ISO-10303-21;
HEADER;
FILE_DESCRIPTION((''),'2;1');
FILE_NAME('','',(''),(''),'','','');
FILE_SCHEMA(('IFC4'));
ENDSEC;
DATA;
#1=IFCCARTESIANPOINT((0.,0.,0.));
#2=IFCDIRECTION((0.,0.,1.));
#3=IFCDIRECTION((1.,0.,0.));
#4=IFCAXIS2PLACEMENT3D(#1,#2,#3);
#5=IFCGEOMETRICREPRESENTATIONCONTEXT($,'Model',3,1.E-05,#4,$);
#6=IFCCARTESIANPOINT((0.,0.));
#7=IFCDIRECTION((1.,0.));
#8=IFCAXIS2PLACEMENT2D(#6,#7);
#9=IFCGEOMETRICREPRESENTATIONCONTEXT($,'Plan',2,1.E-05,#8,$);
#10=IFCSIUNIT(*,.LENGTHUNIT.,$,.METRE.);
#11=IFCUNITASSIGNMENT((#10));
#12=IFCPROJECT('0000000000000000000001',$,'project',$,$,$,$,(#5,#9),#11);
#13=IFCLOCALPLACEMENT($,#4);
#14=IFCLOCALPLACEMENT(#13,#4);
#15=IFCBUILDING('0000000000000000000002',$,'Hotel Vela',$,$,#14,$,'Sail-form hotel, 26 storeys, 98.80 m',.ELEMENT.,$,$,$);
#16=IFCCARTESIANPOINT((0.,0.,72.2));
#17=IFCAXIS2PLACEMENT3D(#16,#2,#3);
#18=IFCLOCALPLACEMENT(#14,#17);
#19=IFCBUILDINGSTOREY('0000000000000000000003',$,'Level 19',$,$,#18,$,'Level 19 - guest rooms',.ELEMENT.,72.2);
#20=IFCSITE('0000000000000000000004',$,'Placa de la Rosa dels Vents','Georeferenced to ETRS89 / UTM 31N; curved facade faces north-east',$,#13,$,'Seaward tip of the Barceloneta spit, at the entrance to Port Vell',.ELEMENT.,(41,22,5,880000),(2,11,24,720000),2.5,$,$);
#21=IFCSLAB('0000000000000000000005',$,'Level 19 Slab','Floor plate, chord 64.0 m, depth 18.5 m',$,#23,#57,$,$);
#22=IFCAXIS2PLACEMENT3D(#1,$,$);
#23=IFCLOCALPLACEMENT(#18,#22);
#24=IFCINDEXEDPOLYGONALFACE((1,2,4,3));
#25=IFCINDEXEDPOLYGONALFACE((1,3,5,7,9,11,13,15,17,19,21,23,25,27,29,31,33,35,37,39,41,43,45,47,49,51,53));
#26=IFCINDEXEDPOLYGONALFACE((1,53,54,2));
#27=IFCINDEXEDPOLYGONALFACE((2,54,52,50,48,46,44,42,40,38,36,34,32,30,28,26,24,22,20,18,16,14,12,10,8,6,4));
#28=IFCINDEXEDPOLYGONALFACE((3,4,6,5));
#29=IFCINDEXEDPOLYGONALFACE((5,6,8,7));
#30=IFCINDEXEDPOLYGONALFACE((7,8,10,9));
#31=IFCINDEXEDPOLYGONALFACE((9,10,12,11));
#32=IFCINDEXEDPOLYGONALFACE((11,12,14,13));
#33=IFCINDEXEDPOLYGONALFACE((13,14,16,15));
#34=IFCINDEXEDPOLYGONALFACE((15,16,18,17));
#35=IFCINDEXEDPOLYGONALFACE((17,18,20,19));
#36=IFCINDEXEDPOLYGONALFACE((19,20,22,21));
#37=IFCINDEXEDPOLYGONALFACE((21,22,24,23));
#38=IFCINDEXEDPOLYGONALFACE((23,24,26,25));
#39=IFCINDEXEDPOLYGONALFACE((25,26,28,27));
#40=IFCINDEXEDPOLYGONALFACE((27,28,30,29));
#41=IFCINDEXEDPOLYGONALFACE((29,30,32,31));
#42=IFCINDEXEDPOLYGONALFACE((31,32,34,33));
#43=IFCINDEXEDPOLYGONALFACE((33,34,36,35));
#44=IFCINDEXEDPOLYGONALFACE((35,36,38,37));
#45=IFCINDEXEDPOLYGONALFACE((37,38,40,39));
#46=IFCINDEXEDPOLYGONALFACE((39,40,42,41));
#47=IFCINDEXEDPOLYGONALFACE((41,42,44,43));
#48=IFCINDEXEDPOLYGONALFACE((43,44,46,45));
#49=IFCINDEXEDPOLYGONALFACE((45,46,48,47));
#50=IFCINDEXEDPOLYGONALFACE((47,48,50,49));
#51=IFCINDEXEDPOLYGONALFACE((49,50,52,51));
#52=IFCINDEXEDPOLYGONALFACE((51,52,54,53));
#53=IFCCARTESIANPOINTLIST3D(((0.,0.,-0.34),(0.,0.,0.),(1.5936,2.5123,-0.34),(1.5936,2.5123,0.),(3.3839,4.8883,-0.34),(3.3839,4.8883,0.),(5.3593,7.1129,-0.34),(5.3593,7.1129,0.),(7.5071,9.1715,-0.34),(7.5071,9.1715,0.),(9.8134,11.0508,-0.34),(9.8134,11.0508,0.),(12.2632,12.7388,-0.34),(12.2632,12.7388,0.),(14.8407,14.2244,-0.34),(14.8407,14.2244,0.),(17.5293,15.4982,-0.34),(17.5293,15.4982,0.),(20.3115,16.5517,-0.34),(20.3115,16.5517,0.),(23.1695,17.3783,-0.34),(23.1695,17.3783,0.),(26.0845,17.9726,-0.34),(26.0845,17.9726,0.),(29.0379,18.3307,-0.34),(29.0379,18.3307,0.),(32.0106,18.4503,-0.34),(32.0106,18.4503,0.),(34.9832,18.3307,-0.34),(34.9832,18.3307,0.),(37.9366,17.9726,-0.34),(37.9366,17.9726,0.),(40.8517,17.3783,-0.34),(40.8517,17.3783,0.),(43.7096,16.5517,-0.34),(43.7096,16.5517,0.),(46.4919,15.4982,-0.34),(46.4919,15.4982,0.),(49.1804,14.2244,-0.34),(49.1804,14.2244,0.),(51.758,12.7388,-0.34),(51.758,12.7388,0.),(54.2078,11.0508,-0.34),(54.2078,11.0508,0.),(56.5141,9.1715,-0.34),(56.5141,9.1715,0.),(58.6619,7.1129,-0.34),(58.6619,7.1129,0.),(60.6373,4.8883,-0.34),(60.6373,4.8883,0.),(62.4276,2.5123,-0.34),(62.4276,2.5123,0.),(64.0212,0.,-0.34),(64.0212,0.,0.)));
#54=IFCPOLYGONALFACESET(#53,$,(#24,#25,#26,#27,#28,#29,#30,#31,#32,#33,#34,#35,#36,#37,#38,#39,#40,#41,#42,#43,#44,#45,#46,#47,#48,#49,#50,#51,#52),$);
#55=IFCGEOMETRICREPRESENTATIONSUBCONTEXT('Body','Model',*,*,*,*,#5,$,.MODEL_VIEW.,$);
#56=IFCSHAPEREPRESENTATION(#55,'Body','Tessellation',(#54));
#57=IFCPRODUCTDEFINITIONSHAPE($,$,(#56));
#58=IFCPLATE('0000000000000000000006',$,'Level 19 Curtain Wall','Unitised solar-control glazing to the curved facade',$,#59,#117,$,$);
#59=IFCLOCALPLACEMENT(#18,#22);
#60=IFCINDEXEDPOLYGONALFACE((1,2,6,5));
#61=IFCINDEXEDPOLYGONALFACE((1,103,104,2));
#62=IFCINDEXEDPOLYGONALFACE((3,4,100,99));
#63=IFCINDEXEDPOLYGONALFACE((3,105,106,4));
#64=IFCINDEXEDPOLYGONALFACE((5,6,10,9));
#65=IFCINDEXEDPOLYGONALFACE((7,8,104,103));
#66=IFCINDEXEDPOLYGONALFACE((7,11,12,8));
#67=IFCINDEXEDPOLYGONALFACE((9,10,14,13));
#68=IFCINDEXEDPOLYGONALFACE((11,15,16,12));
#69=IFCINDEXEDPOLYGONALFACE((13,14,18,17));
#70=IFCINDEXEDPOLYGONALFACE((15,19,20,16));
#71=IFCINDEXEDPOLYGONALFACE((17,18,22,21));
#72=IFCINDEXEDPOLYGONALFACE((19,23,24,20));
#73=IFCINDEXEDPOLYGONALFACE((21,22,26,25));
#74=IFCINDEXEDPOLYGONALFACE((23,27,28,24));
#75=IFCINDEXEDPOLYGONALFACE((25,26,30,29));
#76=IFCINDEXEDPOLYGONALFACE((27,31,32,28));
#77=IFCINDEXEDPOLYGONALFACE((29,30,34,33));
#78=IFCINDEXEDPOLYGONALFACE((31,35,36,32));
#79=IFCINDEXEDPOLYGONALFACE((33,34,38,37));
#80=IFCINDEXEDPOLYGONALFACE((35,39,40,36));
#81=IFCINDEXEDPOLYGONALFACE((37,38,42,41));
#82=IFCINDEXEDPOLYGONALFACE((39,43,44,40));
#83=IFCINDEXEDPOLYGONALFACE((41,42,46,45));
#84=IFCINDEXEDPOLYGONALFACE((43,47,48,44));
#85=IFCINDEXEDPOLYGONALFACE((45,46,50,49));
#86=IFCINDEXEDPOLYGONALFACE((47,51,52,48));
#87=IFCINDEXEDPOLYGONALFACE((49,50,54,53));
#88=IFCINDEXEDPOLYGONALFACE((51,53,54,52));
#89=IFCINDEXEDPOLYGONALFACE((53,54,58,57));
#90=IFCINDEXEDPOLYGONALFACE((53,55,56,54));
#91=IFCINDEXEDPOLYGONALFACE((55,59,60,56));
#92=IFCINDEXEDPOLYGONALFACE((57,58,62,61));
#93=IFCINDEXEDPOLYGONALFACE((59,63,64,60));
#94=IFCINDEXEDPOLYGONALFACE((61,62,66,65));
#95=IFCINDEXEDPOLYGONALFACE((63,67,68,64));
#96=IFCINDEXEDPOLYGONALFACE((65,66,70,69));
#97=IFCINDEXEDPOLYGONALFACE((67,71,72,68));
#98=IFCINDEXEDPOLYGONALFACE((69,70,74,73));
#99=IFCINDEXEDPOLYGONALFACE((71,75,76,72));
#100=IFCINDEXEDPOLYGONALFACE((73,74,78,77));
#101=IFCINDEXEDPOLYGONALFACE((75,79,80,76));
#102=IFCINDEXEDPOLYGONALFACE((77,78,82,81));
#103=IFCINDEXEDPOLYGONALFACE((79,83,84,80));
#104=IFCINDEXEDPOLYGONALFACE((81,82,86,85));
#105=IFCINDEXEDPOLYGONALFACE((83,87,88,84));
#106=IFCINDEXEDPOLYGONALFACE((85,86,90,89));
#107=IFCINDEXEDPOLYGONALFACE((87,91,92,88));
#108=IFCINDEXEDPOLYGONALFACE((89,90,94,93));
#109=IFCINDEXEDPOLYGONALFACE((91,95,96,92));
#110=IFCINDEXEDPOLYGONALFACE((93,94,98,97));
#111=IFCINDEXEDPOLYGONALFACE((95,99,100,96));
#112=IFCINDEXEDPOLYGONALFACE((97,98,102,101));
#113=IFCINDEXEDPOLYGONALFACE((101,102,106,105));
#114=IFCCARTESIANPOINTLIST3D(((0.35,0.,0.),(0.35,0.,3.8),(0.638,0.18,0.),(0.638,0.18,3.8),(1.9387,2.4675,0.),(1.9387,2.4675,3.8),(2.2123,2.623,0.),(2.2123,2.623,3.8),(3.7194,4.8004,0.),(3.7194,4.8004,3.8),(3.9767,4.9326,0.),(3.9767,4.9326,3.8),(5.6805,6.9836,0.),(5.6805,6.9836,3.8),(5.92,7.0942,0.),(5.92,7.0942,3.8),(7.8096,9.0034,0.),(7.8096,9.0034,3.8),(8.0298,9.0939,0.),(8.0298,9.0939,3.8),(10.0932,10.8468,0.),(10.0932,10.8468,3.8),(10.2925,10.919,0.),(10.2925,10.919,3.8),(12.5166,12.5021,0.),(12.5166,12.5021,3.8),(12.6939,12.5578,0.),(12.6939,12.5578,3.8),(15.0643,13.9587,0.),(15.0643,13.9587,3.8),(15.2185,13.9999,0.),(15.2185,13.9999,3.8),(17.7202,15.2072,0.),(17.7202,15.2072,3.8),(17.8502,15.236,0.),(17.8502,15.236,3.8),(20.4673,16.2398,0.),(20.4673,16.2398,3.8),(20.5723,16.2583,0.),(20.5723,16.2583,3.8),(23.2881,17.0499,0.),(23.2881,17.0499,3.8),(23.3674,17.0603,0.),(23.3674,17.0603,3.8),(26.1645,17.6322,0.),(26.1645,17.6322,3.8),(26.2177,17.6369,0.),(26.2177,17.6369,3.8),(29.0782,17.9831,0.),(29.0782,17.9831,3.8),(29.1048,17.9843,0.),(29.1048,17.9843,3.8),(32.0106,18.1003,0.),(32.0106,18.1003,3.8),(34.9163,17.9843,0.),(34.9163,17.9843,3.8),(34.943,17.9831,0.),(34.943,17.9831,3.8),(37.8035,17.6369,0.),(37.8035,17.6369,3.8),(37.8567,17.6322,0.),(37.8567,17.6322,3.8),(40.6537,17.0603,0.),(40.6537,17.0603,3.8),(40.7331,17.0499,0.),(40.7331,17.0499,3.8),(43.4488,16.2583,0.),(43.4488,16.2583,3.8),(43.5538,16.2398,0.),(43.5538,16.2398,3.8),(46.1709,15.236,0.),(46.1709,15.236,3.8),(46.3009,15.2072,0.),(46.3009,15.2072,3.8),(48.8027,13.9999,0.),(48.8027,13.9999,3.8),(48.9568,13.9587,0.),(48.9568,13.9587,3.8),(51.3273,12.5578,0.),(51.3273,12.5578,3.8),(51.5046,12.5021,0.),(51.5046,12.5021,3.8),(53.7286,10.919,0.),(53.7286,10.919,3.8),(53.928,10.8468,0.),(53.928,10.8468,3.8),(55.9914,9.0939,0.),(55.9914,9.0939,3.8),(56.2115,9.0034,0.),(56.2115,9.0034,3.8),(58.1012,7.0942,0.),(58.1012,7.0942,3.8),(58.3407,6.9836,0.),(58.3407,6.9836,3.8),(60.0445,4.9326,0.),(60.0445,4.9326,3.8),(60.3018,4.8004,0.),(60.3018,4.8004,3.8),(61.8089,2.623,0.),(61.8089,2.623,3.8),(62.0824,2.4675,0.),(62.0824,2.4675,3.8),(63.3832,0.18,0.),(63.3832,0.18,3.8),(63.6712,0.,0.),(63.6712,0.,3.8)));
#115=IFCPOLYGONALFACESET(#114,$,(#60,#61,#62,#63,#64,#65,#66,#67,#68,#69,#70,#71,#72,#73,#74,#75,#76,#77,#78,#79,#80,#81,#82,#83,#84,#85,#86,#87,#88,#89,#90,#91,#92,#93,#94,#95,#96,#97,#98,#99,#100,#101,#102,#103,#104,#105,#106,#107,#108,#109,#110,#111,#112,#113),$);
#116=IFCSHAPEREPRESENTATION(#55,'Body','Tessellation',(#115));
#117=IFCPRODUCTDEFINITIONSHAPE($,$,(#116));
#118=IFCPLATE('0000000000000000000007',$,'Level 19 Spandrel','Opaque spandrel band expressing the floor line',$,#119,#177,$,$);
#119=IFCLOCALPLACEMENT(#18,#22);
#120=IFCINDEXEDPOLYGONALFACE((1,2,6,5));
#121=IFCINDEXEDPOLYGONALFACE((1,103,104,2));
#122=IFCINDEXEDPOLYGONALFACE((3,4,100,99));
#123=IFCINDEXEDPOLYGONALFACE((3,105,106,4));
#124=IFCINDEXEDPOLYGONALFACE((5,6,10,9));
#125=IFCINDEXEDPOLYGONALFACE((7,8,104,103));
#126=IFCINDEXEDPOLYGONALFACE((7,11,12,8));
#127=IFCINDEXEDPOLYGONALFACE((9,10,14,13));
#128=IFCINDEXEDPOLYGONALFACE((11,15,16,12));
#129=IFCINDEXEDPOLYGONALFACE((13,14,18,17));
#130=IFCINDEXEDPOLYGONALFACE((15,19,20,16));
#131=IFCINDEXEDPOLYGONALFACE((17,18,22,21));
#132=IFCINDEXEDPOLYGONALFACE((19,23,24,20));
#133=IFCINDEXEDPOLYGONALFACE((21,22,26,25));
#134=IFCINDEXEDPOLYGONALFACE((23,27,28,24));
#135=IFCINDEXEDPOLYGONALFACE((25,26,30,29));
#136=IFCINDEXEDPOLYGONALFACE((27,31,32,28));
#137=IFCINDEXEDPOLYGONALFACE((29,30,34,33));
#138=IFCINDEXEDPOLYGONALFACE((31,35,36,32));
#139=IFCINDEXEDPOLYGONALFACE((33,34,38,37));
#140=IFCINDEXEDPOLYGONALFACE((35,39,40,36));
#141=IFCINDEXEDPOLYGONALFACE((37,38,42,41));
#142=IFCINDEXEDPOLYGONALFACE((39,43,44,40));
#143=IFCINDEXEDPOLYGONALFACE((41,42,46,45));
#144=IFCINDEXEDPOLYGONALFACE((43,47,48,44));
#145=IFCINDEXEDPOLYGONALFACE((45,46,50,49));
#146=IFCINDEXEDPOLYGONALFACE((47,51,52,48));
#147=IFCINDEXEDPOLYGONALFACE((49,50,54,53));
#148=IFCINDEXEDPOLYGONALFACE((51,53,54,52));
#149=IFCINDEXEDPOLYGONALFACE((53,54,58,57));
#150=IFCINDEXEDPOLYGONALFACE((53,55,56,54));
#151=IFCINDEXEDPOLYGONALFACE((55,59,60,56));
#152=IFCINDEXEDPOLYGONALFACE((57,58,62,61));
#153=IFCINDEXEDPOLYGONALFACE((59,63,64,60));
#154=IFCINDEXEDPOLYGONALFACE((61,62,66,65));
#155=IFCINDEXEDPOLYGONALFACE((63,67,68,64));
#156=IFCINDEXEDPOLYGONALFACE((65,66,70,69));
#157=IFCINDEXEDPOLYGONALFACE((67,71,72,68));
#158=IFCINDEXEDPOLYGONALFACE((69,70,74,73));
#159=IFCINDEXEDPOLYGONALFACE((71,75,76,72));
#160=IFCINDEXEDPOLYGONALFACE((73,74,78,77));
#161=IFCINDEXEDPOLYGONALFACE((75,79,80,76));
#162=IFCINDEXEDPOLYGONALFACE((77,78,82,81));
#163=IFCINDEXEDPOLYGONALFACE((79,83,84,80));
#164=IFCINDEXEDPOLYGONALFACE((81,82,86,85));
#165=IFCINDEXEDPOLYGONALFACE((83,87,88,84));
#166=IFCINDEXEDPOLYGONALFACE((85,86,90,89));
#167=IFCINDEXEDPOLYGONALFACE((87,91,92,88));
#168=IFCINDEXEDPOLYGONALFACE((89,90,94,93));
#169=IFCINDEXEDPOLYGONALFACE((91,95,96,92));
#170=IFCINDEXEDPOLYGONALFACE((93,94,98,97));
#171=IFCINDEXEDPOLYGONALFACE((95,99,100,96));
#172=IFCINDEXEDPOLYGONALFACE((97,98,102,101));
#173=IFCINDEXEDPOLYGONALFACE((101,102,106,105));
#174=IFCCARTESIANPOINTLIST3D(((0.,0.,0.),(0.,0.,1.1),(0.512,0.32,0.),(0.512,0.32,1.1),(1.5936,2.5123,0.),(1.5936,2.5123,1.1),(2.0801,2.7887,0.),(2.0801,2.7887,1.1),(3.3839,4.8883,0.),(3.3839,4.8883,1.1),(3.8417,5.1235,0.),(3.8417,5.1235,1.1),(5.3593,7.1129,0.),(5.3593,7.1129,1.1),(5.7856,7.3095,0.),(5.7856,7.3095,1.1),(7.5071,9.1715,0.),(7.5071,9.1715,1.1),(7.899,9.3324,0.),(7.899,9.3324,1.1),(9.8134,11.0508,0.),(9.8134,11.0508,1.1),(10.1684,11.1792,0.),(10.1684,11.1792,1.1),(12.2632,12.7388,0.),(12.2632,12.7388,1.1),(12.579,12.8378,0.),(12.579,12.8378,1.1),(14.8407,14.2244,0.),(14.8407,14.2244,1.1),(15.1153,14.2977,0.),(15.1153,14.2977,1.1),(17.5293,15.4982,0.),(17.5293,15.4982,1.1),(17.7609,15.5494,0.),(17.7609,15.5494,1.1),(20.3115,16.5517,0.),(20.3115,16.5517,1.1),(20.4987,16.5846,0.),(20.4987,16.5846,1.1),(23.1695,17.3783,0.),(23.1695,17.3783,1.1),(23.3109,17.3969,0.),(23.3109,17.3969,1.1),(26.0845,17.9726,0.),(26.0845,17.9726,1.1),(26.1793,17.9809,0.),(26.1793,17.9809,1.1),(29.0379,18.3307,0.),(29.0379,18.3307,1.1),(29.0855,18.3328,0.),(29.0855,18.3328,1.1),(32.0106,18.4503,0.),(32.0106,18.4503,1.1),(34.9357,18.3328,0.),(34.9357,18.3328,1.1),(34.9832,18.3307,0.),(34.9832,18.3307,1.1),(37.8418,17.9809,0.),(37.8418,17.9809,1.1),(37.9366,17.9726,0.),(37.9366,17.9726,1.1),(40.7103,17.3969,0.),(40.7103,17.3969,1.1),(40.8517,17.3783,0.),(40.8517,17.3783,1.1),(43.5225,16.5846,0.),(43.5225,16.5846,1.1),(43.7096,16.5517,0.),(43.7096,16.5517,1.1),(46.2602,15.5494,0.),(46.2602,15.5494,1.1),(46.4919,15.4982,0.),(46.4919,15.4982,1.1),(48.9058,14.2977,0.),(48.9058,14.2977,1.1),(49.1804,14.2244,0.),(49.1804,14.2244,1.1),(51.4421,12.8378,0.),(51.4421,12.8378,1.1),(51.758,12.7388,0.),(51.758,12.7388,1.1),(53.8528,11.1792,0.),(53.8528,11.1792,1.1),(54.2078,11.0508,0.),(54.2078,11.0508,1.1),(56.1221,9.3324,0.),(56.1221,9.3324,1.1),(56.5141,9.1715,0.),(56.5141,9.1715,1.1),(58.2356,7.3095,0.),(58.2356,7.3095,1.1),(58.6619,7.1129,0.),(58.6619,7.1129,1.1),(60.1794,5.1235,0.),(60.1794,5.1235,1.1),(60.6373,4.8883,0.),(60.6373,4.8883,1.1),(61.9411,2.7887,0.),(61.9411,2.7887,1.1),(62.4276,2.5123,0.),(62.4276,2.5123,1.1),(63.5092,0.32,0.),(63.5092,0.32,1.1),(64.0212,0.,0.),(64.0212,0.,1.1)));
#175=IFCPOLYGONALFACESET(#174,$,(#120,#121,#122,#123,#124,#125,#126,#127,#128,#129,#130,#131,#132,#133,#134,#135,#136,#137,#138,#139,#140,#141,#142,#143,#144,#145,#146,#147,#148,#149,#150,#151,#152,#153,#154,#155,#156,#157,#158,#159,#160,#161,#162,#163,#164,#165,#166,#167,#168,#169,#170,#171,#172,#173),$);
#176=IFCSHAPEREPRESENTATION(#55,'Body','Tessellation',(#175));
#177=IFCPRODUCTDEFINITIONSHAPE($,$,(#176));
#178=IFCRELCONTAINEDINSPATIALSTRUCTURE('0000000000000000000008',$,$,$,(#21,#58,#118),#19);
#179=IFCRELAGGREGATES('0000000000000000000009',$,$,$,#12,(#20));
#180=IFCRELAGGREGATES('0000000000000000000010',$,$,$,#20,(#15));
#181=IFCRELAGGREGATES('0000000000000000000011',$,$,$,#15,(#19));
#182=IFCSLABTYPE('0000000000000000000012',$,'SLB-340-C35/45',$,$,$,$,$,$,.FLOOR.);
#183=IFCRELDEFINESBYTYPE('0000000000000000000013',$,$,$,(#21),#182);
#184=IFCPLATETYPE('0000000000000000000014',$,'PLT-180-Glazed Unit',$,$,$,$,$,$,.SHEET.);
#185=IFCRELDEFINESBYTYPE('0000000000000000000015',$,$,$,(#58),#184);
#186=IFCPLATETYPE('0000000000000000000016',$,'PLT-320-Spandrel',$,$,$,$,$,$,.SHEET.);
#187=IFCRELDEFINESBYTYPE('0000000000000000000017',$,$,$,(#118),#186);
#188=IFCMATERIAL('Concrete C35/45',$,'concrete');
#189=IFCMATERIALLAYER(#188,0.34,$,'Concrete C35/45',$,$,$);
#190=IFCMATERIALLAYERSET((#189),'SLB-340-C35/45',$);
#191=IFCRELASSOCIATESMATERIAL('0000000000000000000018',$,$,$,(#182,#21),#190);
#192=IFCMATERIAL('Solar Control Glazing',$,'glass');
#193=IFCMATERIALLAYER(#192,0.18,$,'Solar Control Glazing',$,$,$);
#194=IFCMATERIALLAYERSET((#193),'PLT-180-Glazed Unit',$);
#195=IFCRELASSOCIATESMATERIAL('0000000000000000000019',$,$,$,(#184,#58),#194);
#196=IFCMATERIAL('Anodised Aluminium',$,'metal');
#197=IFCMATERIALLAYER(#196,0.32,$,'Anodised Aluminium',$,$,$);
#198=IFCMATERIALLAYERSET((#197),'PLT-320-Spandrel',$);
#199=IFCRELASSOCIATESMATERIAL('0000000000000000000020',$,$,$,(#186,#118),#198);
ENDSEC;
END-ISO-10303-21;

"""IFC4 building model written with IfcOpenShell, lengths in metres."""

from ifc_helpers import new_model, si_unit, frame, origin_with_axes, origin_2d_with_axis, place, context, subcontext, project, spatial, line, indexed_curve, outline, extrude, material, layer, layer_set, layer_usage, type_object, element, save


model = new_model("IFC4")

# Units and contexts
model_context = context("Model", 3, precision=1e-05, world=origin_with_axes())
plan_context = context("Plan", 2, precision=1e-05, world=origin_2d_with_axis())
body_context = subcontext(model_context, "Body", "Model", "MODEL_VIEW")
ifc_project = project(units=[si_unit("LENGTHUNIT", "METRE")], contexts=[model_context, plan_context])

# Site, building, storey
site_placement = place(None, origin_with_axes())
site = spatial("IfcSite", under=ifc_project, at=site_placement, Name="Placa de la Rosa dels Vents", Description="Georeferenced to ETRS89 / UTM 31N; curved facade faces north-east", LongName="Seaward tip of the Barceloneta spit, at the entrance to Port Vell", CompositionType="ELEMENT", RefLatitude=(41, 22, 5, 880000), RefLongitude=(2, 11, 24, 720000), RefElevation=2.5)
building_placement = place(site_placement, origin_with_axes())
building = spatial("IfcBuilding", under=site, at=building_placement, Name="Hotel Vela", LongName="Sail-form hotel, 26 storeys, 98.80 m", CompositionType="ELEMENT")
storey_placement = place(building_placement, frame((0.0, 0.0, 72.2), z_axis=(0.0, 0.0, 1.0), x_axis=(1.0, 0.0, 0.0)))
storey = spatial("IfcBuildingStorey", under=building, at=storey_placement, Name="Level 19", LongName="Level 19 - guest rooms", CompositionType="ELEMENT", Elevation=72.2)

# Slab
ifc_material_1 = material(Name="Concrete C35/45", Category="concrete")
ifc_layer_1 = layer(ifc_material_1, 0.34, Name="Concrete C35/45")
ifc_layer_set_1 = layer_set([ifc_layer_1], Name="SLB-340-C35/45")
ifc_layer_usage_1 = layer_usage(ifc_layer_set_1, "AXIS3", "POSITIVE", 0.0)
slab_type = type_object("IfcSlabType", Name="SLB-340-C35/45", PredefinedType="FLOOR", material=ifc_layer_set_1)
slab_placement = place(storey_placement, frame((0.0, 0.0, -0.34), z_axis=(0.0, 0.0, 1.0), x_axis=(1.0, 0.0, 0.0)))
element("IfcSlab", 1, at=slab_placement, inside=storey, type_object=slab_type, material=ifc_layer_usage_1, Name="Level 19 Slab", Description="Floor plate, chord 64.0 m, depth 18.5 m", context=body_context, shape_type="SweptSolid", body=[
    extrude(outline(indexed_curve([(0.0, 0.0), (64.0212, 0.0), (62.4276, 2.5123), (60.6373, 4.8883), (58.6619, 7.1129), (56.5141, 9.1715), (54.2078, 11.0508), (51.758, 12.7388), (49.1804, 14.2244), (46.4919, 15.4982), (43.7096, 16.5517), (40.8517, 17.3783), (37.9366, 17.9726), (34.9832, 18.3307), (32.0106, 18.4503), (29.0379, 18.3307), (26.0845, 17.9726), (23.1695, 17.3783), (20.3115, 16.5517), (17.5293, 15.4982), (14.8407, 14.2244), (12.2632, 12.7388), (9.8134, 11.0508), (7.5071, 9.1715), (5.3593, 7.1129), (3.3839, 4.8883), (1.5936, 2.5123)], segments=[line(1, 2, 3, 4, 5, 6, 7, 8, 9, 10, 11, 12, 13, 14, 15, 16, 17, 18, 19, 20, 21, 22, 23, 24, 25, 26, 27, 1)])), origin_with_axes(), (0.0, 0.0, 1.0), 0.34),
])

# Plates
ifc_material_2 = material(Name="Solar Control Glazing", Category="glass")
ifc_layer_2 = layer(ifc_material_2, 0.18, Name="Solar Control Glazing")
ifc_layer_set_2 = layer_set([ifc_layer_2], Name="PLT-180-Glazed Unit")
ifc_layer_usage_2 = layer_usage(ifc_layer_set_2, "AXIS2", "POSITIVE", 0.0)
plate_type_1 = type_object("IfcPlateType", Name="PLT-180-Glazed Unit", PredefinedType="SHEET", material=ifc_layer_set_2)
plate_1_placement = place(storey_placement, frame((0.35, 0.0, 0.0), z_axis=(0.0, 0.0, 1.0), x_axis=(1.0, 0.0, 0.0)))
element("IfcPlate", 2, at=plate_1_placement, inside=storey, type_object=plate_type_1, material=ifc_layer_usage_2, Name="Level 19 Curtain Wall", Description="Unitised solar-control glazing to the curved facade", context=body_context, shape_type="SweptSolid", body=[
    extrude(outline(indexed_curve([(63.3212, 0.0), (61.7324, 2.4675), (59.9518, 4.8004), (57.9907, 6.9836), (55.8615, 9.0034), (53.578, 10.8468), (51.1546, 12.5021), (48.6068, 13.9587), (45.9509, 15.2072), (43.2038, 16.2398), (40.3831, 17.0499), (37.5067, 17.6322), (34.593, 17.9831), (31.6606, 18.1003), (28.7282, 17.9831), (25.8145, 17.6322), (22.9381, 17.0499), (20.1173, 16.2398), (17.3702, 15.2072), (14.7143, 13.9587), (12.1666, 12.5021), (9.7432, 10.8468), (7.4596, 9.0034), (5.3305, 6.9836), (3.3694, 4.8004), (1.5887, 2.4675), (0.0, 0.0), (63.0332, 0.18), (1.8623, 2.623), (3.6267, 4.9326), (5.57, 7.0942), (7.6798, 9.0939), (9.9425, 10.919), (12.3439, 12.5578), (14.8685, 13.9999), (17.5002, 15.236), (20.2223, 16.2583), (23.0174, 17.0603), (25.8677, 17.6369), (28.7548, 17.9843), (31.6606, 18.1003), (34.5663, 17.9843), (37.4535, 17.6369), (40.3037, 17.0603), (43.0988, 16.2583), (45.8209, 15.236), (48.4527, 13.9999), (50.9773, 12.5578), (53.3786, 10.919), (55.6414, 9.0939), (57.7512, 7.0942), (59.6945, 4.9326), (61.4589, 2.623), (0.288, 0.18)], segments=[line(1, 2, 3, 4, 5, 6, 7, 8, 9, 10, 11, 12, 13, 14, 15, 16, 17, 18, 19, 20, 21, 22, 23, 24, 25, 26, 27, 28, 29, 30, 31, 32, 33, 34, 35, 36, 37, 38, 39, 40, 41, 42, 43, 44, 45, 46, 47, 48, 49, 50, 51, 52, 53, 54, 1)])), origin_with_axes(), (0.0, 0.0, 1.0), 3.8),
])
ifc_material_3 = material(Name="Anodised Aluminium", Category="metal")
ifc_layer_3 = layer(ifc_material_3, 0.32, Name="Anodised Aluminium")
ifc_layer_set_3 = layer_set([ifc_layer_3], Name="PLT-320-Spandrel")
ifc_layer_usage_3 = layer_usage(ifc_layer_set_3, "AXIS2", "POSITIVE", 0.0)
plate_type_2 = type_object("IfcPlateType", Name="PLT-320-Spandrel", PredefinedType="SHEET", material=ifc_layer_set_3)
plate_2_placement = place(storey_placement, origin_with_axes())
element("IfcPlate", 3, at=plate_2_placement, inside=storey, type_object=plate_type_2, material=ifc_layer_usage_3, Name="Level 19 Spandrel", Description="Opaque spandrel band expressing the floor line", context=body_context, shape_type="SweptSolid", body=[
    extrude(outline(indexed_curve([(64.0212, 0.0), (62.4276, 2.5123), (60.6373, 4.8883), (58.6619, 7.1129), (56.5141, 9.1715), (54.2078, 11.0508), (51.758, 12.7388), (49.1804, 14.2244), (46.4919, 15.4982), (43.7096, 16.5517), (40.8517, 17.3783), (37.9366, 17.9726), (34.9832, 18.3307), (32.0106, 18.4503), (29.0379, 18.3307), (26.0845, 17.9726), (23.1695, 17.3783), (20.3115, 16.5517), (17.5293, 15.4982), (14.8407, 14.2244), (12.2632, 12.7388), (9.8134, 11.0508), (7.5071, 9.1715), (5.3593, 7.1129), (3.3839, 4.8883), (1.5936, 2.5123), (0.0, 0.0), (63.5092, 0.32), (2.0801, 2.7887), (3.8417, 5.1235), (5.7856, 7.3095), (7.899, 9.3324), (10.1684, 11.1792), (12.579, 12.8378), (15.1153, 14.2977), (17.7609, 15.5494), (20.4987, 16.5846), (23.3109, 17.3969), (26.1793, 17.9809), (29.0855, 18.3328), (32.0106, 18.4503), (34.9357, 18.3328), (37.8418, 17.9809), (40.7103, 17.3969), (43.5225, 16.5846), (46.2602, 15.5494), (48.9058, 14.2977), (51.4421, 12.8378), (53.8528, 11.1792), (56.1221, 9.3324), (58.2356, 7.3095), (60.1794, 5.1235), (61.9411, 2.7887), (0.512, 0.32)], segments=[line(1, 2, 3, 4, 5, 6, 7, 8, 9, 10, 11, 12, 13, 14, 15, 16, 17, 18, 19, 20, 21, 22, 23, 24, 25, 26, 27, 28, 29, 30, 31, 32, 33, 34, 35, 36, 37, 38, 39, 40, 41, 42, 43, 44, 45, 46, 47, 48, 49, 50, 51, 52, 53, 54, 1)])), origin_with_axes(), (0.0, 0.0, 1.0), 1.1),
])

save(model, "model.ifc")
